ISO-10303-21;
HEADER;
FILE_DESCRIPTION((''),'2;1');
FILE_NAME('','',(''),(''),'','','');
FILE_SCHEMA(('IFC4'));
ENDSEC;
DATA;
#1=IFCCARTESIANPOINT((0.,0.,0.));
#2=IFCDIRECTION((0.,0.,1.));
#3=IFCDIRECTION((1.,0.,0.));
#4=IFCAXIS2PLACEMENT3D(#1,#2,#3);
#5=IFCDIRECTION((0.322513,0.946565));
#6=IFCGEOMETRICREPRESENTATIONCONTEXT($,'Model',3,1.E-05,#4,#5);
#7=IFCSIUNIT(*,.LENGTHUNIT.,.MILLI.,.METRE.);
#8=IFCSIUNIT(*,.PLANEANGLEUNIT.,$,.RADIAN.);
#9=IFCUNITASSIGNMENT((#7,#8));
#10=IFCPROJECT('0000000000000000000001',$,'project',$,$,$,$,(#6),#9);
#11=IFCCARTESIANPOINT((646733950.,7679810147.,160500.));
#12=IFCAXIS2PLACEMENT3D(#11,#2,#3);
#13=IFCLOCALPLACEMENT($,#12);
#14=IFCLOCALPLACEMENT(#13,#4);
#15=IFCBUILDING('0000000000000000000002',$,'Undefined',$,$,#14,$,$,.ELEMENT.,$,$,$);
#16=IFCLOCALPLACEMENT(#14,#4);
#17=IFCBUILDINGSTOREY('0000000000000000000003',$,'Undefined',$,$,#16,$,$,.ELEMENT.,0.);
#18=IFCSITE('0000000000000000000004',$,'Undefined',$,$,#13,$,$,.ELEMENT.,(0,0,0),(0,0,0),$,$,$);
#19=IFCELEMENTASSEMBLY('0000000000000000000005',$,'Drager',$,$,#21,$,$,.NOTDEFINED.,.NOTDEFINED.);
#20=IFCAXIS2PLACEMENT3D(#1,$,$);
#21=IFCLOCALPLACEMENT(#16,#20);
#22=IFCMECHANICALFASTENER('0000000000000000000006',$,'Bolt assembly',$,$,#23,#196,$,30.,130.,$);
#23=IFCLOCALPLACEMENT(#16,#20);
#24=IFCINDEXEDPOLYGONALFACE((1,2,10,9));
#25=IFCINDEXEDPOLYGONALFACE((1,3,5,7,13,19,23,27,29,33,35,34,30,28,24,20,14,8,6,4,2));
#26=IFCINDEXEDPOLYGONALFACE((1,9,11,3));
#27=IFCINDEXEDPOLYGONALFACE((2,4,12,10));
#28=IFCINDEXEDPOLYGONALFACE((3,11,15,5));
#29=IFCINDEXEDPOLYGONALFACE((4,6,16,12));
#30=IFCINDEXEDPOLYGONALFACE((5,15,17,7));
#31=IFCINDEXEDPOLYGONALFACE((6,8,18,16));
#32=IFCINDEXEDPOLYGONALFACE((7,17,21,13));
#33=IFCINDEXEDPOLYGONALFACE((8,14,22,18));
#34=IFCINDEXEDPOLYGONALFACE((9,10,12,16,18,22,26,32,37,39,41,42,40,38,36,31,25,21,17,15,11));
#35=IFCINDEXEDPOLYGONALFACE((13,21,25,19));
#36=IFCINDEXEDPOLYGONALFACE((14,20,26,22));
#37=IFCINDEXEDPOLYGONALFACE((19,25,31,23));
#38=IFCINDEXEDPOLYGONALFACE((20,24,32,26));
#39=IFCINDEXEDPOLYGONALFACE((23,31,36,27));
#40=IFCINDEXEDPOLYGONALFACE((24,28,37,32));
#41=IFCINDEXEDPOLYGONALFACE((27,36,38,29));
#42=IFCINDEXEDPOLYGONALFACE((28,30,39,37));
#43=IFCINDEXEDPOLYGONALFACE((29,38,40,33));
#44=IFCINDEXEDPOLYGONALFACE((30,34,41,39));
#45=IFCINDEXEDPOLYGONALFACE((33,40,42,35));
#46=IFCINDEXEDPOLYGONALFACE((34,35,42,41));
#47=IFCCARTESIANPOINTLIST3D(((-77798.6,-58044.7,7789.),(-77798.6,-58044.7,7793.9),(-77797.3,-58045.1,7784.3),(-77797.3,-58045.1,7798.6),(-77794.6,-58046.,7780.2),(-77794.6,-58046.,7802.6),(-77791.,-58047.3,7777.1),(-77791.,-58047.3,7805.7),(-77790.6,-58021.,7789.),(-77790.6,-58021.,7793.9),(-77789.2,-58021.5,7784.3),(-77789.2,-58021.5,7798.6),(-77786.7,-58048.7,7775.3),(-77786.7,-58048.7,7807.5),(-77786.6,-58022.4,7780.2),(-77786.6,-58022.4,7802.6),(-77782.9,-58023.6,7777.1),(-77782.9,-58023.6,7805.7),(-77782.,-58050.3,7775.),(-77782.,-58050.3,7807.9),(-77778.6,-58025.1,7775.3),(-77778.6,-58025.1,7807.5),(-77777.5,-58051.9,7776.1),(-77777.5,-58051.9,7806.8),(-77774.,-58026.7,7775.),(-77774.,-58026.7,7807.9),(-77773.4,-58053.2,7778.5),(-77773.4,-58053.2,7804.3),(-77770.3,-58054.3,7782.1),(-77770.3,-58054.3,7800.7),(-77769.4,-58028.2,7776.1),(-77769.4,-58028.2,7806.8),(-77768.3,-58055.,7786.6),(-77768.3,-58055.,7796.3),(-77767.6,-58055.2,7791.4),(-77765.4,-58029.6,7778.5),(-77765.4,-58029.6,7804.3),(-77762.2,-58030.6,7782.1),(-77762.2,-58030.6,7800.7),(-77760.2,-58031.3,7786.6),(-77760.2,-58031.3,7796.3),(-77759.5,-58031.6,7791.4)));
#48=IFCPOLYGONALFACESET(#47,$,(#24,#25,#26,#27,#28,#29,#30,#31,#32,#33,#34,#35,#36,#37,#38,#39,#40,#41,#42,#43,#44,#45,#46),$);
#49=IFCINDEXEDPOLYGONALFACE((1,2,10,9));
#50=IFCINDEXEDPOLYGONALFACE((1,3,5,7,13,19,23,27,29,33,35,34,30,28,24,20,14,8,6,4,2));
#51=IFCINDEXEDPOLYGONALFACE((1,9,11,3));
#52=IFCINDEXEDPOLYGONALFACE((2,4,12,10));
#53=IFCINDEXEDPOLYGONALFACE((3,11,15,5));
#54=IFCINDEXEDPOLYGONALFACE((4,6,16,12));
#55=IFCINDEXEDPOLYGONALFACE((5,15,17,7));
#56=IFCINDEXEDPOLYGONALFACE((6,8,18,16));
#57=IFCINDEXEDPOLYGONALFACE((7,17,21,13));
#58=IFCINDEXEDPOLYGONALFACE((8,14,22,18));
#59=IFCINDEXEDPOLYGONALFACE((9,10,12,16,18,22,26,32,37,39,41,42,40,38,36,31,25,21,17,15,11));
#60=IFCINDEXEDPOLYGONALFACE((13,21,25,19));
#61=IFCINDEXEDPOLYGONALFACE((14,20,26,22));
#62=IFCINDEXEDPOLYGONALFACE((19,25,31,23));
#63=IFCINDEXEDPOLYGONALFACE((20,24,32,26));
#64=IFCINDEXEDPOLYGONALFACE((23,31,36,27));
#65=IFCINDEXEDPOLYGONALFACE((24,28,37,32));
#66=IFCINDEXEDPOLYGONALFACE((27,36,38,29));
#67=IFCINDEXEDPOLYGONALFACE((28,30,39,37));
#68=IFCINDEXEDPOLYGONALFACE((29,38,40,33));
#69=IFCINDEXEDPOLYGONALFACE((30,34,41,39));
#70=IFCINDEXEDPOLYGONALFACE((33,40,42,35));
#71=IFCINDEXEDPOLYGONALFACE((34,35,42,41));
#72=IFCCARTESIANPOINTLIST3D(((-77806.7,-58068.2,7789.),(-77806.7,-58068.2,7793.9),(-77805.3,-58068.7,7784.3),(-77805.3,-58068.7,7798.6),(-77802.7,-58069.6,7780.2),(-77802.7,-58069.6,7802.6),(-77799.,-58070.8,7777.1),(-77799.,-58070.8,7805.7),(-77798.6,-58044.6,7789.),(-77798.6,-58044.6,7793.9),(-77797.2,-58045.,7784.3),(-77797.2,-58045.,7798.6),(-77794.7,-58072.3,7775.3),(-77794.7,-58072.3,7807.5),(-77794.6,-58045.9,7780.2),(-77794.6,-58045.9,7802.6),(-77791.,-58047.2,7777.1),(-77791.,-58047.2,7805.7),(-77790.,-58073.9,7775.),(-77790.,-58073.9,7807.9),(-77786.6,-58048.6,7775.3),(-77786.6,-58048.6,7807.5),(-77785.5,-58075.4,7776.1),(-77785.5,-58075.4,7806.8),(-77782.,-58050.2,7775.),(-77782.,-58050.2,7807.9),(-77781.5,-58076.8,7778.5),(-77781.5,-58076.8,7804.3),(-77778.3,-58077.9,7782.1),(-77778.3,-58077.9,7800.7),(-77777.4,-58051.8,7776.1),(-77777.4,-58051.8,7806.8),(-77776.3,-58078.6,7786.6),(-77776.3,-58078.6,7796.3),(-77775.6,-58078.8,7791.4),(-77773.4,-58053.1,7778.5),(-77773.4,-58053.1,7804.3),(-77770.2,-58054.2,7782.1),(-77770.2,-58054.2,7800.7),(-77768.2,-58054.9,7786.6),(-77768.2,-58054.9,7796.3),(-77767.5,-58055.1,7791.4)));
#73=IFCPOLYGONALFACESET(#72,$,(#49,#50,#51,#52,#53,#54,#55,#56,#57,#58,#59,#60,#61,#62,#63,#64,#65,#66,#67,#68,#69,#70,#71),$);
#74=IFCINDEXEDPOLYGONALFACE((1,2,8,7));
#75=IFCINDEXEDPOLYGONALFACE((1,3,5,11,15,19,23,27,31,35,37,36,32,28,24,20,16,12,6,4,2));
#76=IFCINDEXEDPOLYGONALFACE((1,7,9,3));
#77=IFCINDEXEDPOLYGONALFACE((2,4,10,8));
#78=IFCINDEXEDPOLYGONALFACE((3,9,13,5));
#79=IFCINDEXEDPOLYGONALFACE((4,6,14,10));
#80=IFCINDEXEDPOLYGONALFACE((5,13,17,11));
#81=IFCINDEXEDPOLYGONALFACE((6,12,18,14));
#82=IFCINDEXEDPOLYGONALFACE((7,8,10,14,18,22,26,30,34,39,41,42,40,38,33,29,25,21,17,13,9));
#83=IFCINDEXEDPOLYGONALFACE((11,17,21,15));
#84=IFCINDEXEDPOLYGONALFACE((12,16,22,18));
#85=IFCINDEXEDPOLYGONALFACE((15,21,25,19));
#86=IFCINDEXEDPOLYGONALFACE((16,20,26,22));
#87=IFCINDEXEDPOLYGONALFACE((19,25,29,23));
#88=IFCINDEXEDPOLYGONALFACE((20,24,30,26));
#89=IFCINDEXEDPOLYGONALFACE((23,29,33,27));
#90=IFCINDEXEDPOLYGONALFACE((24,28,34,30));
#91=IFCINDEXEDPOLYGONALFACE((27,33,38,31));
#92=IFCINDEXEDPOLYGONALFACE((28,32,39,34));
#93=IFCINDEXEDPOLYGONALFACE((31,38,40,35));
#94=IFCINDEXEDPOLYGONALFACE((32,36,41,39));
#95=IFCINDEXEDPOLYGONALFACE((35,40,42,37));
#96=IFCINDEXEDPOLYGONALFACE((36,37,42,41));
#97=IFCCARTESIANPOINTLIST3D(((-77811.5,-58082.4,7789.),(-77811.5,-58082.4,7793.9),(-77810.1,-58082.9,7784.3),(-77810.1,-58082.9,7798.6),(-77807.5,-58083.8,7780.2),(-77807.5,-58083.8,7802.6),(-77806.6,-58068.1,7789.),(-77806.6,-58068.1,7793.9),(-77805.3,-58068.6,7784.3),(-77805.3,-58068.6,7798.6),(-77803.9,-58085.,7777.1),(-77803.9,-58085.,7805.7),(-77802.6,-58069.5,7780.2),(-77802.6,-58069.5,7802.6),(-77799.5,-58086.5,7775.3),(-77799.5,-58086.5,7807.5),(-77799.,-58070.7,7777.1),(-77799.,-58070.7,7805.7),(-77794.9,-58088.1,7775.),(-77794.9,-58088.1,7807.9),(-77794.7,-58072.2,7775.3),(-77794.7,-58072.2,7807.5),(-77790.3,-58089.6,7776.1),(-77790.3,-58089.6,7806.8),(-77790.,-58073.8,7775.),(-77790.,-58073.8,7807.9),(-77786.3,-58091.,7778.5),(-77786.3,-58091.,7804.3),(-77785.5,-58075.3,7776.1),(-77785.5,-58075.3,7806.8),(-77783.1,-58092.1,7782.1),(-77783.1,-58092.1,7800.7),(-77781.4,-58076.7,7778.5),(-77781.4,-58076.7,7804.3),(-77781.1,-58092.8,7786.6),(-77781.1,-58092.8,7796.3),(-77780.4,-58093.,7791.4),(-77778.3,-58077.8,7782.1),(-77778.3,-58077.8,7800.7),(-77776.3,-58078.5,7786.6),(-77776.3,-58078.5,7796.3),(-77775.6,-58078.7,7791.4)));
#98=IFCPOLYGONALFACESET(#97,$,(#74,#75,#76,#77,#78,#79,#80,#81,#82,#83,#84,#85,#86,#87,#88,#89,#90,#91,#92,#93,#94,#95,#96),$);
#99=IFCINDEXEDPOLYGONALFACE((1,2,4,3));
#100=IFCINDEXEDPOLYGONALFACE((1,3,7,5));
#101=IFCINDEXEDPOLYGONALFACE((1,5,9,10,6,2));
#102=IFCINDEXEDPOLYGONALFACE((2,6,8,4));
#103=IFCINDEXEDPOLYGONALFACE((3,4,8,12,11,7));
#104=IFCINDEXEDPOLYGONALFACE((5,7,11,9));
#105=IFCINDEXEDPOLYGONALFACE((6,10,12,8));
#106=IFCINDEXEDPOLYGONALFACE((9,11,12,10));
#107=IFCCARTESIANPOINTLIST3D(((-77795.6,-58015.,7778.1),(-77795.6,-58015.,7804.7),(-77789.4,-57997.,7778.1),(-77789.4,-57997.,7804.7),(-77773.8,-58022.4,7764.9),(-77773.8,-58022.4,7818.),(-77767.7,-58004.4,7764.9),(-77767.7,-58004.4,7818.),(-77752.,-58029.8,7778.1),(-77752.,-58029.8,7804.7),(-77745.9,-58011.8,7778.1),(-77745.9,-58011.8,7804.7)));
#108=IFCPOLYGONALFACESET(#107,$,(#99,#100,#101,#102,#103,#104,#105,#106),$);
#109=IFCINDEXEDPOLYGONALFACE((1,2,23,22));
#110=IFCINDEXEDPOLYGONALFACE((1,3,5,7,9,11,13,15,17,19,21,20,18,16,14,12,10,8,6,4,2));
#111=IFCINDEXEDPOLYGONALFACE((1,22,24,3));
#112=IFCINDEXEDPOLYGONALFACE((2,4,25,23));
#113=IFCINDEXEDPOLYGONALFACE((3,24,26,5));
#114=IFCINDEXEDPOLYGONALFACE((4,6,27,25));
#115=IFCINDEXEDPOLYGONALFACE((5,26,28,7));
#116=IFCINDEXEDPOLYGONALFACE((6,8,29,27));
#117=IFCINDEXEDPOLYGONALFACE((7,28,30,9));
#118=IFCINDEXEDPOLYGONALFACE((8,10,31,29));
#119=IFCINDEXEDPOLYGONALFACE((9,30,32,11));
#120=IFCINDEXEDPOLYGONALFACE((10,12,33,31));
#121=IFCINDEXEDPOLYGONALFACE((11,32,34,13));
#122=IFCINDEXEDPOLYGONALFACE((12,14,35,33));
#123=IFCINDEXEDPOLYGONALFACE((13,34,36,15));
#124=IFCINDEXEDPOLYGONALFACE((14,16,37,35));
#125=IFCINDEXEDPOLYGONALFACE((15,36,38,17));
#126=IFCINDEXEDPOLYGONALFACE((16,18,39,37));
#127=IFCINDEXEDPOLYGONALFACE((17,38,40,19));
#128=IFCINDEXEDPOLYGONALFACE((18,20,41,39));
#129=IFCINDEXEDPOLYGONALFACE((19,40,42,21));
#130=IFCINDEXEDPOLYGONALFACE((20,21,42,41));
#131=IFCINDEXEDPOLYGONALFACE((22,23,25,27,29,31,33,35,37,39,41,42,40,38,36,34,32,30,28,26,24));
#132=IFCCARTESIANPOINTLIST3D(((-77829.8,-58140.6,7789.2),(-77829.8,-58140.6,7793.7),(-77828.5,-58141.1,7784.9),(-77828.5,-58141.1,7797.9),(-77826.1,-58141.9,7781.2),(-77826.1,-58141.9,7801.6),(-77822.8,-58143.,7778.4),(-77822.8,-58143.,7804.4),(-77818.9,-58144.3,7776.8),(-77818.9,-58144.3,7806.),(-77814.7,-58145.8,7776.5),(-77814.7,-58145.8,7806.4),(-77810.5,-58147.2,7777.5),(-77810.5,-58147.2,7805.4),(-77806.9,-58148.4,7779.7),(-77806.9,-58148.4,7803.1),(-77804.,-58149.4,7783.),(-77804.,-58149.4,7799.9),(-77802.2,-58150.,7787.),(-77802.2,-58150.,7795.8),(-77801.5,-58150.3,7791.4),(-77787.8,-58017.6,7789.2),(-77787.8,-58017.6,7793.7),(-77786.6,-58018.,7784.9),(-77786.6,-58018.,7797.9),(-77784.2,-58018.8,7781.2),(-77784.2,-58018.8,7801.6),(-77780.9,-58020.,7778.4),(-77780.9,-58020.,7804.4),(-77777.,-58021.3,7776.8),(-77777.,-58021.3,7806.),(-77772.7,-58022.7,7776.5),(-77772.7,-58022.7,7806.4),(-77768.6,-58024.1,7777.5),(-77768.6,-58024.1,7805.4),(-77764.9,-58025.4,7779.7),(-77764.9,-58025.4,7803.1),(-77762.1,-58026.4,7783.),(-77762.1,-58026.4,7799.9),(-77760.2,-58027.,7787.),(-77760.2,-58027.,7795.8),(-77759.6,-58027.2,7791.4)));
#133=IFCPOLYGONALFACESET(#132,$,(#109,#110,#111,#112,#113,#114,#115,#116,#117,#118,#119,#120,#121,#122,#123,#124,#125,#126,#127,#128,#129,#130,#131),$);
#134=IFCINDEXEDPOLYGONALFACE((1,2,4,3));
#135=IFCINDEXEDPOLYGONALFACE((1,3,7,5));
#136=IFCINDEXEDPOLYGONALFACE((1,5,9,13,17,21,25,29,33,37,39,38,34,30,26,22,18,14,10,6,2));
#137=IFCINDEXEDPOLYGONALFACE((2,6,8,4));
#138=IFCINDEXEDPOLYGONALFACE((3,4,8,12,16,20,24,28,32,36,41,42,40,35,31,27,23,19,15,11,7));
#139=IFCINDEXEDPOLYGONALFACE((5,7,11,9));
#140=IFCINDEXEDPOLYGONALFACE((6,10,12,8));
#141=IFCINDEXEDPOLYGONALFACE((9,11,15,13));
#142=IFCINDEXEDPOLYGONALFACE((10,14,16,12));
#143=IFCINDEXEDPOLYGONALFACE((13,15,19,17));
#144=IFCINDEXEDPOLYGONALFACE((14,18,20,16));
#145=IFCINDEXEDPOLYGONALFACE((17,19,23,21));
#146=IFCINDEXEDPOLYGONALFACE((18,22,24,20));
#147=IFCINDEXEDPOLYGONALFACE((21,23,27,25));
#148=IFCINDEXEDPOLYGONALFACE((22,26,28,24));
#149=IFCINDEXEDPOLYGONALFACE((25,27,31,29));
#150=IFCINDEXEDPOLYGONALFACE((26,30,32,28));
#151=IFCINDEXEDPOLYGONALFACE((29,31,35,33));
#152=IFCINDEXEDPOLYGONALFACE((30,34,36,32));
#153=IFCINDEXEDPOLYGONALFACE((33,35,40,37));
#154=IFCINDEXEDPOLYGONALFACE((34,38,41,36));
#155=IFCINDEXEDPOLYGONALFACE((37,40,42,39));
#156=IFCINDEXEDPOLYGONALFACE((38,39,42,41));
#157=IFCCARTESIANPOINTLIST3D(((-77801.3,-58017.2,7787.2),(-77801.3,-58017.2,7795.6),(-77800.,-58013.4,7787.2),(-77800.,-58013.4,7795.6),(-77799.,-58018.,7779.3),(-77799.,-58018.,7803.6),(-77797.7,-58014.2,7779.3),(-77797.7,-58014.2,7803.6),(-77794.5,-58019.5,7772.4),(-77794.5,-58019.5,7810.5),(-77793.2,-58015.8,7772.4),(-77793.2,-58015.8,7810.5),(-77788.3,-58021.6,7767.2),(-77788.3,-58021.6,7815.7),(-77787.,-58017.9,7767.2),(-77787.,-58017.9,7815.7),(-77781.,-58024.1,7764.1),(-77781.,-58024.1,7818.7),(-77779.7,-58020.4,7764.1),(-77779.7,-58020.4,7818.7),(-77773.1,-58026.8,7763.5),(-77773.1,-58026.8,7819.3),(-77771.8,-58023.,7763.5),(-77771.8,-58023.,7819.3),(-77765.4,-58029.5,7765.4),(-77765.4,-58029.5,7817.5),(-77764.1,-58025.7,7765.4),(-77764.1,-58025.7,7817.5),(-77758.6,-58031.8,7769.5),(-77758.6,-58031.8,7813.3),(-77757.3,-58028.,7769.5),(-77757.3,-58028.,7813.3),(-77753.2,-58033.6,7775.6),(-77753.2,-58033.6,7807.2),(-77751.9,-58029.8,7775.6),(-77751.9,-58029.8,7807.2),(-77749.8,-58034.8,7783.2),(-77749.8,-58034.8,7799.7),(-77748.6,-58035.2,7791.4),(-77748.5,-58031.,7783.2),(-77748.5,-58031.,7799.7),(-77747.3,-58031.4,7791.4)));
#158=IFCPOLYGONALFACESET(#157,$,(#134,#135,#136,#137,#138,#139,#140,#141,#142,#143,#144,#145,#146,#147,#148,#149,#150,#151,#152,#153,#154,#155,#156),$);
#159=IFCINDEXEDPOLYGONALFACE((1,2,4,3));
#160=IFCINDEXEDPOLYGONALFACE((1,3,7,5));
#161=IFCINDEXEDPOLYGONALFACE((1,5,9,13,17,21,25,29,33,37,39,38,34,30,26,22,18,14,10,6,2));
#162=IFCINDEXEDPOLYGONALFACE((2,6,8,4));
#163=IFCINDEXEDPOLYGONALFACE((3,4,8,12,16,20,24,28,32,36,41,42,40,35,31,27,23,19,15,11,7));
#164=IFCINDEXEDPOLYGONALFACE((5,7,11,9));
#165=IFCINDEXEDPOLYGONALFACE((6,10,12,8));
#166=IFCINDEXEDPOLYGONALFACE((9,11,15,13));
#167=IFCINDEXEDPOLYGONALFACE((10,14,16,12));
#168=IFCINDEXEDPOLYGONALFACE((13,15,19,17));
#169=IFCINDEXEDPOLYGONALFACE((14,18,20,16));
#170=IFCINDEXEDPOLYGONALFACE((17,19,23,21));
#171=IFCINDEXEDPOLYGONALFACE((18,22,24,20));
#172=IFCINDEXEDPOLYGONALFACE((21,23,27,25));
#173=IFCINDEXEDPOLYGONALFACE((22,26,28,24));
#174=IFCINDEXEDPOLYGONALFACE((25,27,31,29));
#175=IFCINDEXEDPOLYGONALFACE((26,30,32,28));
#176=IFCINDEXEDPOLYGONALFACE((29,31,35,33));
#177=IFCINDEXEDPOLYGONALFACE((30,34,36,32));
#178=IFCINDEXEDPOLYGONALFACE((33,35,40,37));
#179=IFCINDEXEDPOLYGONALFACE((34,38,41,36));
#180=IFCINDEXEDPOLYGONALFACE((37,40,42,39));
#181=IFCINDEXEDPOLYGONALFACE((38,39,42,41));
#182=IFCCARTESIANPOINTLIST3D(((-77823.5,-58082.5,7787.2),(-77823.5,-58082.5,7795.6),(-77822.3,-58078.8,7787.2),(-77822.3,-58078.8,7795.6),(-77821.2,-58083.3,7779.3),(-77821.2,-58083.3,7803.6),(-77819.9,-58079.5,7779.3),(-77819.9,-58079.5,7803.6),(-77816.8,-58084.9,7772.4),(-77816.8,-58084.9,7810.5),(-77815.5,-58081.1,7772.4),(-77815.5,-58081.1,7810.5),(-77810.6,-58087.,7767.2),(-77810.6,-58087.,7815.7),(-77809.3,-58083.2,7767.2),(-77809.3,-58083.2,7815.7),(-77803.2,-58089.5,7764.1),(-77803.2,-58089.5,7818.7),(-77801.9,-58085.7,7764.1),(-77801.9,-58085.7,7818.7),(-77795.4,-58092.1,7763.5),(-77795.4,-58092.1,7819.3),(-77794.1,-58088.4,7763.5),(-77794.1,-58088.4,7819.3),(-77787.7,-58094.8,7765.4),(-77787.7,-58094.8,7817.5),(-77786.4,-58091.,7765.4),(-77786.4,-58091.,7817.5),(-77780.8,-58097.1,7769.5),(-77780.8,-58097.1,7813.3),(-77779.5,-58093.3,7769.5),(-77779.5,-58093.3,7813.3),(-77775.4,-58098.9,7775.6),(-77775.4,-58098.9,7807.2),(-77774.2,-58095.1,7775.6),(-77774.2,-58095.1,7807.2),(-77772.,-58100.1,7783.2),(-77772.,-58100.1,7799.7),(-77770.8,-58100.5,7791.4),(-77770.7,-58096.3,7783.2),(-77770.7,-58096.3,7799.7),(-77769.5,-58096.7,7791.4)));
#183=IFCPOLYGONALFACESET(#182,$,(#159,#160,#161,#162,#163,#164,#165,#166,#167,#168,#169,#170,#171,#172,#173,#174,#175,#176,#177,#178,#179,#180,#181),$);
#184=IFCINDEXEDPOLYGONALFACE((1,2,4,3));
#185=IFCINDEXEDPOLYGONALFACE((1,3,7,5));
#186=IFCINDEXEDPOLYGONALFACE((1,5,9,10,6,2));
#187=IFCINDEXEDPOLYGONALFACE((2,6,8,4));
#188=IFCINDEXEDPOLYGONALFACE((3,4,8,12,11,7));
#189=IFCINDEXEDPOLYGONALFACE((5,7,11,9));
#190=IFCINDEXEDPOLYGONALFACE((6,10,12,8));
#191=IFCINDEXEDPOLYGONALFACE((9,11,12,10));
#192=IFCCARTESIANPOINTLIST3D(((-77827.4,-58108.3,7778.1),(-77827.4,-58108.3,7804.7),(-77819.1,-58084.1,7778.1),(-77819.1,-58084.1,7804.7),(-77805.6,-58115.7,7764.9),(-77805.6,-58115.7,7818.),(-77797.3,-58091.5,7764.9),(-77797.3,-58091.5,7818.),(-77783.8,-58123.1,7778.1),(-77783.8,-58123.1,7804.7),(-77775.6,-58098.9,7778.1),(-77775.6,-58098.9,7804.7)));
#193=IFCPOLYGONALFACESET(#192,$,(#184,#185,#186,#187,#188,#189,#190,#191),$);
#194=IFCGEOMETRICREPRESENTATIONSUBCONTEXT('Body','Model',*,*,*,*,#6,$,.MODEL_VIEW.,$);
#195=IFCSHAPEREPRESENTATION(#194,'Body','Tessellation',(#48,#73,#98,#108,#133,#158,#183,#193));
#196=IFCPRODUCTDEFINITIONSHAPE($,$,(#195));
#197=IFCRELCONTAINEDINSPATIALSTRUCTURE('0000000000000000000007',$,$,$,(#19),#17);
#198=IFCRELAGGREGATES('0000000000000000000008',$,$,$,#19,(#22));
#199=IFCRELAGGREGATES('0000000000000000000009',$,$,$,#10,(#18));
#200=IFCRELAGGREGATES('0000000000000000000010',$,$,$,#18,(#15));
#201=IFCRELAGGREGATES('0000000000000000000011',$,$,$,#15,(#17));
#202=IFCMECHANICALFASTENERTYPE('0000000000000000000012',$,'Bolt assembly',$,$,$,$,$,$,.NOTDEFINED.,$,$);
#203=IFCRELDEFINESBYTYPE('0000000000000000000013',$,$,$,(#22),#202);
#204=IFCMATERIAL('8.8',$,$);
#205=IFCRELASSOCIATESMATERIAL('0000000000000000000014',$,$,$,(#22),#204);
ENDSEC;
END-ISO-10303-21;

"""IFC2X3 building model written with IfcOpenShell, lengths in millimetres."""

from ifc_helpers import new_model, si_unit, direction, frame, origin_with_axes, origin_2d_with_axis, place, context, subcontext, project, spatial, polyline, circle, outline, extrude, source, transform, mapped, material, type_object, element, aggregate, save


model = new_model("IFC2X3")

# Units and contexts
model_context = context("Model", 3, precision=1e-05, world=origin_with_axes(), true_north=direction((0.322513, 0.946565)))
body_context = subcontext(model_context, "Body", "Model", "MODEL_VIEW")
ifc_project = project(units=[si_unit("LENGTHUNIT", "METRE", prefix="MILLI"), si_unit("PLANEANGLEUNIT", "RADIAN")], contexts=[model_context])

# Site, building, storey
site_placement = place(None, frame((646733950.0, 7679810147.0, 160500.0), z_axis=(0.0, 0.0, 1.0), x_axis=(1.0, 0.0, 0.0)))
site = spatial("IfcSite", under=ifc_project, at=site_placement, Name="Undefined", CompositionType="ELEMENT", RefLatitude=(0, 0, 0), RefLongitude=(0, 0, 0))
building_placement = place(site_placement, origin_with_axes())
building = spatial("IfcBuilding", under=site, at=building_placement, Name="Undefined", CompositionType="ELEMENT")
storey_placement = place(building_placement, origin_with_axes())
storey = spatial("IfcBuildingStorey", under=building, at=storey_placement, Name="Undefined", CompositionType="ELEMENT", Elevation=0.0)

# Element assembly
assembly_1_placement = place(storey_placement, origin_with_axes())
assembly_1 = element("IfcElementAssembly", 1, at=assembly_1_placement, inside=storey, Name="Drager", AssemblyPlace="NOTDEFINED", PredefinedType="NOTDEFINED")

# Shared definitions
ifc_material_1 = material(Name="8.8")
mechanical_fastener_type = type_object("IfcMechanicalFastenerType", Name="Bolt assembly")

# Mechanical fastener
shared_shape_1 = source(origin_with_axes(), body_context, "Body", "SweptSolid", [
    extrude(circle(Radius=16.5, at=origin_2d_with_axis()), frame((0.0, -57.4, 0.0), z_axis=(0.0, 1.0, 0.0), x_axis=(1.0, 0.0, 0.0)), (0.0, 0.0, 1.0), 25.0),
    extrude(circle(Radius=16.5, at=origin_2d_with_axis()), frame((0.0, -32.5, 0.0), z_axis=(0.0, 1.0, 0.0), x_axis=(1.0, 0.0, 0.0)), (0.0, 0.0, 1.0), 25.0),
    extrude(circle(Radius=16.5, at=origin_2d_with_axis()), frame((0.0, -7.6, 0.0), z_axis=(0.0, 1.0, 0.0), x_axis=(1.0, 0.0, 0.0)), (0.0, 0.0, 1.0), 15.1),
    extrude(outline(polyline([(23.0, -13.3), (23.0, 13.3), (0.0, 26.6), (-23.0, 13.3), (-23.0, -13.3), (0.0, -26.6), (23.0, -13.3)])), frame((0.0, -80.5, 0.0), z_axis=(0.0, 1.0, 0.0), x_axis=(1.0, 0.0, 0.0)), (0.0, 0.0, 1.0), 19.0),
    extrude(circle(Radius=15.0, at=origin_2d_with_axis()), frame((0.0, -61.5, 0.0), z_axis=(0.0, 1.0, 0.0), x_axis=(1.0, 0.0, 0.0)), (0.0, 0.0, 1.0), 130.0),
    extrude(circle(Radius=28.0, at=origin_2d_with_axis()), frame((0.0, -61.5, 0.0), z_axis=(0.0, 1.0, 0.0), x_axis=(1.0, 0.0, 0.0)), (0.0, 0.0, 1.0), 4.0),
    extrude(circle(Radius=28.0, at=origin_2d_with_axis()), frame((0.0, 7.5, 0.0), z_axis=(0.0, 1.0, 0.0), x_axis=(1.0, 0.0, 0.0)), (0.0, 0.0, 1.0), 4.0),
    extrude(outline(polyline([(23.0, -13.3), (23.0, 13.3), (0.0, 26.6), (-23.0, 13.3), (-23.0, -13.3), (0.0, -26.6), (23.0, -13.3)])), frame((0.0, 11.5, 0.0), z_axis=(0.0, 1.0, 0.0), x_axis=(1.0, 0.0, 0.0)), (0.0, 0.0, 1.0), 25.6),
])
mechanical_fastener_1_placement = place(assembly_1_placement, frame((-77793.6, -58080.6, 7791.4), z_axis=(0.0, 0.0, -1.0), x_axis=(0.946565, -0.322513, 0.0)))
mechanical_fastener_1 = element("IfcMechanicalFastener", 2, at=mechanical_fastener_1_placement, type_object=mechanical_fastener_type, material=ifc_material_1, Name="Bolt assembly", NominalDiameter=30.0, NominalLength=130.0, context=body_context, shape_type="MappedRepresentation", body=[
    mapped(shared_shape_1, transform((0.0, 0.0, 0.0))),
])
aggregate(assembly_1, [mechanical_fastener_1])

save(model, "model.ifc")
